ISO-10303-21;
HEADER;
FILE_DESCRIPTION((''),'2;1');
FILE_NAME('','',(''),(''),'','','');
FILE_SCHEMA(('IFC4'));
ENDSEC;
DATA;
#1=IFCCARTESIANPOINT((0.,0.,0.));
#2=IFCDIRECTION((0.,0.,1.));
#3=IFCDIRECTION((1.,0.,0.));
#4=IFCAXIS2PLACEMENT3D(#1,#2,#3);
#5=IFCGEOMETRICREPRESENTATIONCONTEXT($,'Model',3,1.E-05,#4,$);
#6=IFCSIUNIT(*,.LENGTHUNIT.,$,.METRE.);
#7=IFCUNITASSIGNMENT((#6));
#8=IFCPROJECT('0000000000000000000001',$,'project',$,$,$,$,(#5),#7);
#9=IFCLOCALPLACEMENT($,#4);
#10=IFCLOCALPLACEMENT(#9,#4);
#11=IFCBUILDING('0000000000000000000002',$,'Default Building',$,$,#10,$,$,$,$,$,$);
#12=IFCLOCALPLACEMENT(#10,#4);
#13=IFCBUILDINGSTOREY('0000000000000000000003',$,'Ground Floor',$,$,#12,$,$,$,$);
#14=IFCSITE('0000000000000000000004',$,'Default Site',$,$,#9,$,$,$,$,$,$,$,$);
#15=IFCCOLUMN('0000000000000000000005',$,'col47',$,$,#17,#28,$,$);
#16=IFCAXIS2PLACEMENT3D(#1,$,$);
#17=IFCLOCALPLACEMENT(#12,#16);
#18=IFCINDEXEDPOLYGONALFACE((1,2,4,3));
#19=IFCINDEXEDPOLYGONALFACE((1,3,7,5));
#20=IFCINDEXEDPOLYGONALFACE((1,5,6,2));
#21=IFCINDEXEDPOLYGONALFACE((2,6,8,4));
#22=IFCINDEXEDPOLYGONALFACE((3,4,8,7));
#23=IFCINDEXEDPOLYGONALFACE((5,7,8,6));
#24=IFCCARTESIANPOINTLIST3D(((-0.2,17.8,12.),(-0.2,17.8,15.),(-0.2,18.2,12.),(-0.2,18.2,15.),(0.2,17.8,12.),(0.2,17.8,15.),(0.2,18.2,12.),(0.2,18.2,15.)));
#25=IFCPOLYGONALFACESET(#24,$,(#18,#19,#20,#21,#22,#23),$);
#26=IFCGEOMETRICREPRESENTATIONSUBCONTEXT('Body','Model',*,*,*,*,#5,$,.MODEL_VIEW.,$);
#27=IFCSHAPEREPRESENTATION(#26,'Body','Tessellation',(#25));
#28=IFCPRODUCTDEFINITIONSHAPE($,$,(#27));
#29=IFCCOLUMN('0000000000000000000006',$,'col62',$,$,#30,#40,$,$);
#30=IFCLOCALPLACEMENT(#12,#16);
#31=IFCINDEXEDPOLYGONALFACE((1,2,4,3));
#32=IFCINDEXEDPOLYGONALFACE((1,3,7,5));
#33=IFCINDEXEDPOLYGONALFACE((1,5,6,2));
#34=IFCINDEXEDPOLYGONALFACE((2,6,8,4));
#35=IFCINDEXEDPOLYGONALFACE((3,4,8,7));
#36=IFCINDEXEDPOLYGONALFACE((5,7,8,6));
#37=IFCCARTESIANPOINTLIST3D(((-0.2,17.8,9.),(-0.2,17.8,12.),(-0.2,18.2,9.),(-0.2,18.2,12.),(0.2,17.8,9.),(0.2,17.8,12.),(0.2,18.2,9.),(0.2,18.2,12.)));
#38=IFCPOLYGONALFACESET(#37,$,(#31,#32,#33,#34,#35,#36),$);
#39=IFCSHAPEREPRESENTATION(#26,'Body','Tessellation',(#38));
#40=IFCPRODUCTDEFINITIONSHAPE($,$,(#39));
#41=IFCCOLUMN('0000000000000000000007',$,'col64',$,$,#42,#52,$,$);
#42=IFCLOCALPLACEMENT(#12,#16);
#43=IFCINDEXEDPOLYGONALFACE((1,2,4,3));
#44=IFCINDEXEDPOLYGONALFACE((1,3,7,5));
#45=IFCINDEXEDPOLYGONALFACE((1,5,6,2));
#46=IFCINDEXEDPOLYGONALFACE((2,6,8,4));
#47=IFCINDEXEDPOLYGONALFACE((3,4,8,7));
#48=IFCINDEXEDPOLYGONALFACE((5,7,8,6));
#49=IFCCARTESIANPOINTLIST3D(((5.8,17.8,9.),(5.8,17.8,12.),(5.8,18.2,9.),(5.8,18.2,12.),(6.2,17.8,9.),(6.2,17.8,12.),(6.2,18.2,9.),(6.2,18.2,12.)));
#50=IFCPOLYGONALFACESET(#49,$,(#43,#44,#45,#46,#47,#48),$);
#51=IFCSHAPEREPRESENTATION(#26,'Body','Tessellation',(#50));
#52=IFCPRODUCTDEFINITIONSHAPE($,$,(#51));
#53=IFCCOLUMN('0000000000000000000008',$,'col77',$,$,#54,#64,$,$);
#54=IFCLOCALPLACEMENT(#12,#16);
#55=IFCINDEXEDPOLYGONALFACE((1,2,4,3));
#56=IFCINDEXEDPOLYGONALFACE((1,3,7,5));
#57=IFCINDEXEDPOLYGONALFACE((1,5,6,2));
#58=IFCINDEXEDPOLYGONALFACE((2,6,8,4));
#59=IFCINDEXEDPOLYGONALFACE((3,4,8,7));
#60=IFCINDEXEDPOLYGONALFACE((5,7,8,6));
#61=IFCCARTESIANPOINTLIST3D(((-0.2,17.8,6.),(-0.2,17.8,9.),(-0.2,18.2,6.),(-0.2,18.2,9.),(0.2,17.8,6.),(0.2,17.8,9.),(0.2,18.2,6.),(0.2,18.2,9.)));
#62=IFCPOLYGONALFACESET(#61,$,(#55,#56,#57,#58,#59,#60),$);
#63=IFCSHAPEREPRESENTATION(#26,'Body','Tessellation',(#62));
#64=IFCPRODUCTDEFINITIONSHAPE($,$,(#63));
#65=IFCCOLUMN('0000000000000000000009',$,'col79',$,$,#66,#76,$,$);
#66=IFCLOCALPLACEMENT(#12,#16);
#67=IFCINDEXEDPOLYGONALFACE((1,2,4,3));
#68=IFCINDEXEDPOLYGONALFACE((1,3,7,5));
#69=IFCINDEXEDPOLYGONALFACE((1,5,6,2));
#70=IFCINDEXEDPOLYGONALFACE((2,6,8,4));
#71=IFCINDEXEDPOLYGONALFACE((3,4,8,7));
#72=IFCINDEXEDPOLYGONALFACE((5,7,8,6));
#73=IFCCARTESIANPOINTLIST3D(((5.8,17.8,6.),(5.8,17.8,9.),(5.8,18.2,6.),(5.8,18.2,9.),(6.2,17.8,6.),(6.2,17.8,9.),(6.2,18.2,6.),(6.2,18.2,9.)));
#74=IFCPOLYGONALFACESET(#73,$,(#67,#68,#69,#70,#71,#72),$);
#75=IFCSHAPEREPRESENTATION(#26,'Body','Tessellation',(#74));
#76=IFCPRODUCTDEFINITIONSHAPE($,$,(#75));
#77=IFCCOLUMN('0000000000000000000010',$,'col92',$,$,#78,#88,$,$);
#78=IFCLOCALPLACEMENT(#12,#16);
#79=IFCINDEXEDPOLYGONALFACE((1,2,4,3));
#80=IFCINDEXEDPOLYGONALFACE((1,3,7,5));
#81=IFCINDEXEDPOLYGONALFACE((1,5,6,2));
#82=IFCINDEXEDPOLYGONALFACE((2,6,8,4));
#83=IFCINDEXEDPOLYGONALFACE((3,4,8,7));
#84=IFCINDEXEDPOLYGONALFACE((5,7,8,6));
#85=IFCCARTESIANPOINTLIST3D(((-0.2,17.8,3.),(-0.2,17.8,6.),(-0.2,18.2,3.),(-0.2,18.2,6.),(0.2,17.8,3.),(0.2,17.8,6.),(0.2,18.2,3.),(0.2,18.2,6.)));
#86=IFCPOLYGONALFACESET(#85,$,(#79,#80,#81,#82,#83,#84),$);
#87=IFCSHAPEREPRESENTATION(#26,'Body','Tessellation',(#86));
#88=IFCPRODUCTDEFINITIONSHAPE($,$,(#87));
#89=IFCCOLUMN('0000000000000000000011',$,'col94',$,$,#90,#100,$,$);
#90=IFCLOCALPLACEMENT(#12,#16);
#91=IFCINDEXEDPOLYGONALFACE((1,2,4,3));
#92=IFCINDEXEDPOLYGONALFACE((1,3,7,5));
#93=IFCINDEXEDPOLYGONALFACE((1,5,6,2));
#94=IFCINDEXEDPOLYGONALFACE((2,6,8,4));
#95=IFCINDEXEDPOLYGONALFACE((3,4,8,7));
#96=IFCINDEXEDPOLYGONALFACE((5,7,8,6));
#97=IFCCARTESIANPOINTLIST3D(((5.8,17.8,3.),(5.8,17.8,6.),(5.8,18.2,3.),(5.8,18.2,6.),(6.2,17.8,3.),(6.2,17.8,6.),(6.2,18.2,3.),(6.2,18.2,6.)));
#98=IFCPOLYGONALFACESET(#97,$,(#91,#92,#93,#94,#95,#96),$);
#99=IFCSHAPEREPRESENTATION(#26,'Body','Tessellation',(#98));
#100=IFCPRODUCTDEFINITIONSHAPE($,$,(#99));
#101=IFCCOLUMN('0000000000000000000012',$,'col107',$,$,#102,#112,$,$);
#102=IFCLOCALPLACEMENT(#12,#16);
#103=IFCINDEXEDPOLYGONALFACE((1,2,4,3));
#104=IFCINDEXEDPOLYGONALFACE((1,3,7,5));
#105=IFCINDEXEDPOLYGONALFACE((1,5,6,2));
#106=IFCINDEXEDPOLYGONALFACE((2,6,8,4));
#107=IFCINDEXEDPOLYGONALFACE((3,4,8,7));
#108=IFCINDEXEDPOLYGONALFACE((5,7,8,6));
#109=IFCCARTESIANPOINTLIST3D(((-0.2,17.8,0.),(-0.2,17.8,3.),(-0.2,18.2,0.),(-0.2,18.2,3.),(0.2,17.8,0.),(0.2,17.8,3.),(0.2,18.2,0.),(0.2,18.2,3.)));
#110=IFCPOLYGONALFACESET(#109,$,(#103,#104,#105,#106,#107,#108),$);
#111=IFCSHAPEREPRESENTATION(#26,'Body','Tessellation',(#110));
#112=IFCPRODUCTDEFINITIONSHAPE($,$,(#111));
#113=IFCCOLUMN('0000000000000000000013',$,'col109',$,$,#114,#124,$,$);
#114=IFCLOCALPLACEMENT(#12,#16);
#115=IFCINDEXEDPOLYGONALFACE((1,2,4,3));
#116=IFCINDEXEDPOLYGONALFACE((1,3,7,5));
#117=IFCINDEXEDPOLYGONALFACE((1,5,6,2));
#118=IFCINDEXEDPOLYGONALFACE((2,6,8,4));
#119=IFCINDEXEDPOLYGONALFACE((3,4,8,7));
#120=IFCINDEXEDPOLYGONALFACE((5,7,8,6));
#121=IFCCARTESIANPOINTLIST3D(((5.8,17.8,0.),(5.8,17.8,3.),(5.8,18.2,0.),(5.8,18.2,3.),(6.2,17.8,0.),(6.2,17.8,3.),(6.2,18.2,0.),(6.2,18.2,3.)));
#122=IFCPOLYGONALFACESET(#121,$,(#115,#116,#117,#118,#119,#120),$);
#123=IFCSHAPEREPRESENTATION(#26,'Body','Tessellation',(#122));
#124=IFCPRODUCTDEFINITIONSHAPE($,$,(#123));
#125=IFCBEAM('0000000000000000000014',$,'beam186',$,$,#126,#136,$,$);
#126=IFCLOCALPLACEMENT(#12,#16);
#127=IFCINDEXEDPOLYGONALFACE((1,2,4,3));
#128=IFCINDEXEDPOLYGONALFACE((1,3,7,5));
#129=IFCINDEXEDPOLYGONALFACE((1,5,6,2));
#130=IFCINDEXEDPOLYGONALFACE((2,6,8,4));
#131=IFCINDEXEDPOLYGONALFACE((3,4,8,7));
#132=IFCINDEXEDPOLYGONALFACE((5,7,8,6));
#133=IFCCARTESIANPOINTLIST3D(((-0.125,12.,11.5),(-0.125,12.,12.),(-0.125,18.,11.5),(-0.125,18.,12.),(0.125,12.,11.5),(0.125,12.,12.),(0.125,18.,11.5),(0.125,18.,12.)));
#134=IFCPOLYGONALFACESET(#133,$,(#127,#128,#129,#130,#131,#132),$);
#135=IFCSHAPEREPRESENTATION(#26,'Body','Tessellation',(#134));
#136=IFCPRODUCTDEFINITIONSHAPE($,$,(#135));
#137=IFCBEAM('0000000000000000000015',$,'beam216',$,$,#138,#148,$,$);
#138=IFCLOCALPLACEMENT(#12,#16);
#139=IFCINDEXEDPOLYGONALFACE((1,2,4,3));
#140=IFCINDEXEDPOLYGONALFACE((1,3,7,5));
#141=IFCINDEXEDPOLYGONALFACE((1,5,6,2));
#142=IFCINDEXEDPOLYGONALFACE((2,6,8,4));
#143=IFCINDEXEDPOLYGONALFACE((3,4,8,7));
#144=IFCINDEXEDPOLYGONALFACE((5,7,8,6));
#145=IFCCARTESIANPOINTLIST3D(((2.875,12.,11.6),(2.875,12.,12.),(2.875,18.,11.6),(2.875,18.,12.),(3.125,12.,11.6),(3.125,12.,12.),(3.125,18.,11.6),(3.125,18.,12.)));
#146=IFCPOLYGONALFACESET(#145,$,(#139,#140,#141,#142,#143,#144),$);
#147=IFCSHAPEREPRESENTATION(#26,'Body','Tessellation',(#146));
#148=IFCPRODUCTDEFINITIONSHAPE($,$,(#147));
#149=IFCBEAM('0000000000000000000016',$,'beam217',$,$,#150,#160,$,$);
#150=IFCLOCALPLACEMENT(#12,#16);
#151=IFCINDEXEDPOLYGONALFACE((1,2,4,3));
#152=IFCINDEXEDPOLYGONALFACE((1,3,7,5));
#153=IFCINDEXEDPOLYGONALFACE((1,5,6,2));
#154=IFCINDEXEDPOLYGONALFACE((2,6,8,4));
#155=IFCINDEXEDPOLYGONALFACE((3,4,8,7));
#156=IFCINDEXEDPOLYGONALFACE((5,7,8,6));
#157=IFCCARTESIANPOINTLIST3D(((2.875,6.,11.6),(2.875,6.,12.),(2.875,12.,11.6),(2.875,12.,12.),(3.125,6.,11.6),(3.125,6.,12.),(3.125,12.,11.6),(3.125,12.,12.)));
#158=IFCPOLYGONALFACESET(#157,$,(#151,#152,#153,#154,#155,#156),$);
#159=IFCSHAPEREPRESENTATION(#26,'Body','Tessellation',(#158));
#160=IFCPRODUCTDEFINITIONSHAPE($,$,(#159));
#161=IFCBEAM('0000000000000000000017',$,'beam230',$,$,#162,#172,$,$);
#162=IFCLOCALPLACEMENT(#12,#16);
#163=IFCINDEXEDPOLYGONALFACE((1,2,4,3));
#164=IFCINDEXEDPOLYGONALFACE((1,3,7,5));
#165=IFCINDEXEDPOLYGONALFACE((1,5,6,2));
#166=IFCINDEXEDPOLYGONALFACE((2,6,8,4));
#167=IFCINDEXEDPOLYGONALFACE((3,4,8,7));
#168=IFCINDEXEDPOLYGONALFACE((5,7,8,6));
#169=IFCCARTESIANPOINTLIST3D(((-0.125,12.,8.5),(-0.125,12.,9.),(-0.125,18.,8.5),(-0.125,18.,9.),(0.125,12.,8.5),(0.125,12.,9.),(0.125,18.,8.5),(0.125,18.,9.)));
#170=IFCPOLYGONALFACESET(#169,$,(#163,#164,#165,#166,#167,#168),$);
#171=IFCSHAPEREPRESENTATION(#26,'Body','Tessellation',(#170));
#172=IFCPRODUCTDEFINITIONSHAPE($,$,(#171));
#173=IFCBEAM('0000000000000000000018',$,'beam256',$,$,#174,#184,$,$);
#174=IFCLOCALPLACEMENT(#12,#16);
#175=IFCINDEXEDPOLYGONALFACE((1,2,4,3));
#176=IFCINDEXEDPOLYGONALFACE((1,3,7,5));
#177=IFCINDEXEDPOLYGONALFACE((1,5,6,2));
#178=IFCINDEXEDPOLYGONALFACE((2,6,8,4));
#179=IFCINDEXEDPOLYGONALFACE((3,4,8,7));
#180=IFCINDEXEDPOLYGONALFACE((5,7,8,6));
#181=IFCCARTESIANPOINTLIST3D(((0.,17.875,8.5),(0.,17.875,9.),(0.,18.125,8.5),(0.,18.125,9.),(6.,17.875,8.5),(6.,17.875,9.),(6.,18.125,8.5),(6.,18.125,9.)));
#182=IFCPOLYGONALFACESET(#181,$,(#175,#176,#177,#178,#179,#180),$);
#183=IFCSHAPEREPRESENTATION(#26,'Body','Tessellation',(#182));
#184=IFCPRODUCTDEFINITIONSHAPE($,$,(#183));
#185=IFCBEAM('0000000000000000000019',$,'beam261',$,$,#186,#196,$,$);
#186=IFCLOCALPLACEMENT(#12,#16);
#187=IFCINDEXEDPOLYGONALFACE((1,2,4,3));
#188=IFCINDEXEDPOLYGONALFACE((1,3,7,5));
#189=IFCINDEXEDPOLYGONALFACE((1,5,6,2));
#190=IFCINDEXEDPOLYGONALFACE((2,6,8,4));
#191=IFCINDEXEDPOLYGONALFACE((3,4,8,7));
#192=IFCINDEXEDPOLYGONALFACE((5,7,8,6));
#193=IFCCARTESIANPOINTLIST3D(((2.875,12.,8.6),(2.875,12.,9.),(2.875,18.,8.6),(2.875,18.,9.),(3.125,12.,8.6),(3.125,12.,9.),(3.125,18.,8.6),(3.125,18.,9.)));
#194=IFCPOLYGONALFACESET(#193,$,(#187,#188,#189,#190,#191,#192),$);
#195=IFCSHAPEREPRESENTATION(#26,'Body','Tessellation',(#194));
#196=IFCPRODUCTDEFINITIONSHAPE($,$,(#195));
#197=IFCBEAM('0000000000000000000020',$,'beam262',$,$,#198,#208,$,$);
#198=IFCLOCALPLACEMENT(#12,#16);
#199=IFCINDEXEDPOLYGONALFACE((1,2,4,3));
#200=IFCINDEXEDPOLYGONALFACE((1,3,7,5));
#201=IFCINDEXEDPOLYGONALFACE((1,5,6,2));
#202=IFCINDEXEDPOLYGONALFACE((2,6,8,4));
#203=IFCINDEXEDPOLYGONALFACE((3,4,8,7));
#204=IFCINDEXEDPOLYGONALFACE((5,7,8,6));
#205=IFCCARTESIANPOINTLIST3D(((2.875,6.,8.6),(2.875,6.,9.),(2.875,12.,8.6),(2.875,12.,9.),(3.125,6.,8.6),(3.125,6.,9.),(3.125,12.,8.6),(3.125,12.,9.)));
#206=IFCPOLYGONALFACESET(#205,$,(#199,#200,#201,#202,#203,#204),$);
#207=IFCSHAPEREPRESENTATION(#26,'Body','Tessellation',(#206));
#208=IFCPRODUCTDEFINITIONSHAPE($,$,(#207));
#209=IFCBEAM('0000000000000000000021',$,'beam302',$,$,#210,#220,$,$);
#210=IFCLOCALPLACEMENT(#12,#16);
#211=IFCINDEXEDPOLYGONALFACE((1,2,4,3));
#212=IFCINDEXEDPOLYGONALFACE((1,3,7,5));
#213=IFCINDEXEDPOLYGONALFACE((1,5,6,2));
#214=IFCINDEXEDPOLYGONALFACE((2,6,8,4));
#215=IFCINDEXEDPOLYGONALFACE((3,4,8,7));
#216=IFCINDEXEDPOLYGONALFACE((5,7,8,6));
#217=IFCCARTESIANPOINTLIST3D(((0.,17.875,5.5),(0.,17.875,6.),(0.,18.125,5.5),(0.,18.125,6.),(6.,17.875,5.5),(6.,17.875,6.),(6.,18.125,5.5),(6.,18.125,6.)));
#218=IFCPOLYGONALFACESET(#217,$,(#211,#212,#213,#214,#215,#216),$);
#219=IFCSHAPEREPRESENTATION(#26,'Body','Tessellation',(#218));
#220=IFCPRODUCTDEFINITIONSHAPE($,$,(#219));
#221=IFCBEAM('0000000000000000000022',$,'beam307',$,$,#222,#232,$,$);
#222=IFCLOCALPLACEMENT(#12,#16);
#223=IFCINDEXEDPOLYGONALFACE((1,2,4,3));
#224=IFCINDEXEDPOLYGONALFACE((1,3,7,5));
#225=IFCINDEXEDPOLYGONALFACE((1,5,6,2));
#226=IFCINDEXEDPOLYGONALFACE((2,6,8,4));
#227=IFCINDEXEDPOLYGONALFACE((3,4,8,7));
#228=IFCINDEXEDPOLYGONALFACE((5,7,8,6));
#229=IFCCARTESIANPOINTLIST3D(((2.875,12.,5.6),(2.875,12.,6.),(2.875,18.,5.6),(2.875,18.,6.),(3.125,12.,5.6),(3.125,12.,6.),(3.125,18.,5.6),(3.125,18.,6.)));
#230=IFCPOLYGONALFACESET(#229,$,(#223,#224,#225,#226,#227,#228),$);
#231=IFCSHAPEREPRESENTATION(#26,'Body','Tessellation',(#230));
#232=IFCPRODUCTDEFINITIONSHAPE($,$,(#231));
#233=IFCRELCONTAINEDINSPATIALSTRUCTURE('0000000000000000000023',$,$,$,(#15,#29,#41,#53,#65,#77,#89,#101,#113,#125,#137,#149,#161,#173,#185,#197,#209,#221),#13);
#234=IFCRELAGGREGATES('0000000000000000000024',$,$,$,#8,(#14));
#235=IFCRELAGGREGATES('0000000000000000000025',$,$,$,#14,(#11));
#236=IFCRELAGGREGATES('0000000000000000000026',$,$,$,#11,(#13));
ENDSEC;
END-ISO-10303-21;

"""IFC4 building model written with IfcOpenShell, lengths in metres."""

from ifc_helpers import new_model, si_unit, frame, origin_with_axes, place, context, subcontext, project, spatial, indexed_curve, outline, extrude, element, save


model = new_model("IFC4")

# Units and contexts
model_context = context("Model", 3, precision=1e-05, world=origin_with_axes())
body_context = subcontext(model_context, "Body", "Model", "MODEL_VIEW")
ifc_project = project(units=[si_unit("LENGTHUNIT", "METRE")], contexts=[model_context])

# Site, building, storey
site_placement = place(None, origin_with_axes())
site = spatial("IfcSite", under=ifc_project, at=site_placement, Name="Default Site")
building_placement = place(site_placement, origin_with_axes())
building = spatial("IfcBuilding", under=site, at=building_placement, Name="Default Building")
storey_placement = place(building_placement, origin_with_axes())
storey = spatial("IfcBuildingStorey", under=building, at=storey_placement, Name="Ground Floor")

# Columns
for number, where, z_axis, x_axis, name in (
    (1, (-0.2, 17.8, 12.0), (0.0, 0.0, 1.0), (1.0, 0.0, 0.0), "col47"),
    (2, (-0.2, 17.8, 9.0), (0.0, 0.0, 1.0), (1.0, 0.0, 0.0), "col62"),
    (3, (5.8, 17.8, 9.0), (0.0, 0.0, 1.0), (1.0, 0.0, 0.0), "col64"),
    (4, (-0.2, 17.8, 6.0), (0.0, 0.0, 1.0), (1.0, 0.0, 0.0), "col77"),
    (5, (5.8, 17.8, 6.0), (0.0, 0.0, 1.0), (1.0, 0.0, 0.0), "col79"),
    (6, (-0.2, 17.8, 3.0), (0.0, 0.0, 1.0), (1.0, 0.0, 0.0), "col92"),
    (7, (5.8, 17.8, 3.0), (0.0, 0.0, 1.0), (1.0, 0.0, 0.0), "col94"),
    (8, (-0.2, 17.8, 0.0), (0.0, 0.0, 1.0), (1.0, 0.0, 0.0), "col107"),
    (9, (5.8, 17.8, 0.0), (0.0, 0.0, 1.0), (1.0, 0.0, 0.0), "col109"),
):
    element("IfcColumn", number, at=place(storey_placement, frame(where, z_axis=z_axis, x_axis=x_axis)), inside=storey, Name=name, context=body_context, shape_type="SweptSolid", body=[
        extrude(outline(indexed_curve([(0.0, 0.0), (0.0, 0.4), (0.4, 0.4), (0.4, 0.0), (0.0, 0.0)], self_intersect=False)), origin_with_axes(), (0.0, 0.0, 1.0), 3.0),
    ])

# Beams
beam_1_placement = place(storey_placement, frame((0.125, 12.0, 11.5), z_axis=(0.0, 0.0, 1.0), x_axis=(0.0, 1.0, 0.0)))
element("IfcBeam", 10, at=beam_1_placement, inside=storey, Name="beam186", context=body_context, shape_type="SweptSolid", body=[
    extrude(outline(indexed_curve([(0.0, 0.0), (0.0, 0.25), (6.0, 0.25), (6.0, 0.0), (0.0, 0.0)], self_intersect=False)), origin_with_axes(), (0.0, 0.0, 1.0), 0.5),
])
for number, where, z_axis, x_axis, name in (
    (11, (2.875, 18.0, 11.6), (0.0, 0.0, 1.0), (0.0, -1.0, 0.0), "beam216"),
    (12, (2.875, 12.0, 11.6), (0.0, 0.0, 1.0), (0.0, -1.0, 0.0), "beam217"),
):
    element("IfcBeam", number, at=place(storey_placement, frame(where, z_axis=z_axis, x_axis=x_axis)), inside=storey, Name=name, context=body_context, shape_type="SweptSolid", body=[
        extrude(outline(indexed_curve([(0.0, 0.0), (0.0, 0.25), (6.0, 0.25), (6.0, 0.0), (0.0, 0.0)], self_intersect=False)), origin_with_axes(), (0.0, 0.0, 1.0), 0.4),
    ])
for number, where, z_axis, x_axis, name in (
    (13, (0.125, 12.0, 8.5), (0.0, 0.0, 1.0), (0.0, 1.0, 0.0), "beam230"),
    (14, (0.0, 17.875, 8.5), (0.0, 0.0, 1.0), (1.0, 0.0, 0.0), "beam256"),
):
    element("IfcBeam", number, at=place(storey_placement, frame(where, z_axis=z_axis, x_axis=x_axis)), inside=storey, Name=name, context=body_context, shape_type="SweptSolid", body=[
        extrude(outline(indexed_curve([(0.0, 0.0), (0.0, 0.25), (6.0, 0.25), (6.0, 0.0), (0.0, 0.0)], self_intersect=False)), origin_with_axes(), (0.0, 0.0, 1.0), 0.5),
    ])
for number, where, z_axis, x_axis, name in (
    (15, (2.875, 18.0, 8.6), (0.0, 0.0, 1.0), (0.0, -1.0, 0.0), "beam261"),
    (16, (2.875, 12.0, 8.6), (0.0, 0.0, 1.0), (0.0, -1.0, 0.0), "beam262"),
):
    element("IfcBeam", number, at=place(storey_placement, frame(where, z_axis=z_axis, x_axis=x_axis)), inside=storey, Name=name, context=body_context, shape_type="SweptSolid", body=[
        extrude(outline(indexed_curve([(0.0, 0.0), (0.0, 0.25), (6.0, 0.25), (6.0, 0.0), (0.0, 0.0)], self_intersect=False)), origin_with_axes(), (0.0, 0.0, 1.0), 0.4),
    ])
beam_2_placement = place(storey_placement, frame((0.0, 17.875, 5.5), z_axis=(0.0, 0.0, 1.0), x_axis=(1.0, 0.0, 0.0)))
element("IfcBeam", 17, at=beam_2_placement, inside=storey, Name="beam302", context=body_context, shape_type="SweptSolid", body=[
    extrude(outline(indexed_curve([(0.0, 0.0), (0.0, 0.25), (6.0, 0.25), (6.0, 0.0), (0.0, 0.0)], self_intersect=False)), origin_with_axes(), (0.0, 0.0, 1.0), 0.5),
])
for number, where, z_axis, x_axis, name in (
    (18, (2.875, 18.0, 5.6), (0.0, 0.0, 1.0), (0.0, -1.0, 0.0), "beam307"),
):
    element("IfcBeam", number, at=place(storey_placement, frame(where, z_axis=z_axis, x_axis=x_axis)), inside=storey, Name=name, context=body_context, shape_type="SweptSolid", body=[
        extrude(outline(indexed_curve([(0.0, 0.0), (0.0, 0.25), (6.0, 0.25), (6.0, 0.0), (0.0, 0.0)], self_intersect=False)), origin_with_axes(), (0.0, 0.0, 1.0), 0.4),
    ])

save(model, "model.ifc")
